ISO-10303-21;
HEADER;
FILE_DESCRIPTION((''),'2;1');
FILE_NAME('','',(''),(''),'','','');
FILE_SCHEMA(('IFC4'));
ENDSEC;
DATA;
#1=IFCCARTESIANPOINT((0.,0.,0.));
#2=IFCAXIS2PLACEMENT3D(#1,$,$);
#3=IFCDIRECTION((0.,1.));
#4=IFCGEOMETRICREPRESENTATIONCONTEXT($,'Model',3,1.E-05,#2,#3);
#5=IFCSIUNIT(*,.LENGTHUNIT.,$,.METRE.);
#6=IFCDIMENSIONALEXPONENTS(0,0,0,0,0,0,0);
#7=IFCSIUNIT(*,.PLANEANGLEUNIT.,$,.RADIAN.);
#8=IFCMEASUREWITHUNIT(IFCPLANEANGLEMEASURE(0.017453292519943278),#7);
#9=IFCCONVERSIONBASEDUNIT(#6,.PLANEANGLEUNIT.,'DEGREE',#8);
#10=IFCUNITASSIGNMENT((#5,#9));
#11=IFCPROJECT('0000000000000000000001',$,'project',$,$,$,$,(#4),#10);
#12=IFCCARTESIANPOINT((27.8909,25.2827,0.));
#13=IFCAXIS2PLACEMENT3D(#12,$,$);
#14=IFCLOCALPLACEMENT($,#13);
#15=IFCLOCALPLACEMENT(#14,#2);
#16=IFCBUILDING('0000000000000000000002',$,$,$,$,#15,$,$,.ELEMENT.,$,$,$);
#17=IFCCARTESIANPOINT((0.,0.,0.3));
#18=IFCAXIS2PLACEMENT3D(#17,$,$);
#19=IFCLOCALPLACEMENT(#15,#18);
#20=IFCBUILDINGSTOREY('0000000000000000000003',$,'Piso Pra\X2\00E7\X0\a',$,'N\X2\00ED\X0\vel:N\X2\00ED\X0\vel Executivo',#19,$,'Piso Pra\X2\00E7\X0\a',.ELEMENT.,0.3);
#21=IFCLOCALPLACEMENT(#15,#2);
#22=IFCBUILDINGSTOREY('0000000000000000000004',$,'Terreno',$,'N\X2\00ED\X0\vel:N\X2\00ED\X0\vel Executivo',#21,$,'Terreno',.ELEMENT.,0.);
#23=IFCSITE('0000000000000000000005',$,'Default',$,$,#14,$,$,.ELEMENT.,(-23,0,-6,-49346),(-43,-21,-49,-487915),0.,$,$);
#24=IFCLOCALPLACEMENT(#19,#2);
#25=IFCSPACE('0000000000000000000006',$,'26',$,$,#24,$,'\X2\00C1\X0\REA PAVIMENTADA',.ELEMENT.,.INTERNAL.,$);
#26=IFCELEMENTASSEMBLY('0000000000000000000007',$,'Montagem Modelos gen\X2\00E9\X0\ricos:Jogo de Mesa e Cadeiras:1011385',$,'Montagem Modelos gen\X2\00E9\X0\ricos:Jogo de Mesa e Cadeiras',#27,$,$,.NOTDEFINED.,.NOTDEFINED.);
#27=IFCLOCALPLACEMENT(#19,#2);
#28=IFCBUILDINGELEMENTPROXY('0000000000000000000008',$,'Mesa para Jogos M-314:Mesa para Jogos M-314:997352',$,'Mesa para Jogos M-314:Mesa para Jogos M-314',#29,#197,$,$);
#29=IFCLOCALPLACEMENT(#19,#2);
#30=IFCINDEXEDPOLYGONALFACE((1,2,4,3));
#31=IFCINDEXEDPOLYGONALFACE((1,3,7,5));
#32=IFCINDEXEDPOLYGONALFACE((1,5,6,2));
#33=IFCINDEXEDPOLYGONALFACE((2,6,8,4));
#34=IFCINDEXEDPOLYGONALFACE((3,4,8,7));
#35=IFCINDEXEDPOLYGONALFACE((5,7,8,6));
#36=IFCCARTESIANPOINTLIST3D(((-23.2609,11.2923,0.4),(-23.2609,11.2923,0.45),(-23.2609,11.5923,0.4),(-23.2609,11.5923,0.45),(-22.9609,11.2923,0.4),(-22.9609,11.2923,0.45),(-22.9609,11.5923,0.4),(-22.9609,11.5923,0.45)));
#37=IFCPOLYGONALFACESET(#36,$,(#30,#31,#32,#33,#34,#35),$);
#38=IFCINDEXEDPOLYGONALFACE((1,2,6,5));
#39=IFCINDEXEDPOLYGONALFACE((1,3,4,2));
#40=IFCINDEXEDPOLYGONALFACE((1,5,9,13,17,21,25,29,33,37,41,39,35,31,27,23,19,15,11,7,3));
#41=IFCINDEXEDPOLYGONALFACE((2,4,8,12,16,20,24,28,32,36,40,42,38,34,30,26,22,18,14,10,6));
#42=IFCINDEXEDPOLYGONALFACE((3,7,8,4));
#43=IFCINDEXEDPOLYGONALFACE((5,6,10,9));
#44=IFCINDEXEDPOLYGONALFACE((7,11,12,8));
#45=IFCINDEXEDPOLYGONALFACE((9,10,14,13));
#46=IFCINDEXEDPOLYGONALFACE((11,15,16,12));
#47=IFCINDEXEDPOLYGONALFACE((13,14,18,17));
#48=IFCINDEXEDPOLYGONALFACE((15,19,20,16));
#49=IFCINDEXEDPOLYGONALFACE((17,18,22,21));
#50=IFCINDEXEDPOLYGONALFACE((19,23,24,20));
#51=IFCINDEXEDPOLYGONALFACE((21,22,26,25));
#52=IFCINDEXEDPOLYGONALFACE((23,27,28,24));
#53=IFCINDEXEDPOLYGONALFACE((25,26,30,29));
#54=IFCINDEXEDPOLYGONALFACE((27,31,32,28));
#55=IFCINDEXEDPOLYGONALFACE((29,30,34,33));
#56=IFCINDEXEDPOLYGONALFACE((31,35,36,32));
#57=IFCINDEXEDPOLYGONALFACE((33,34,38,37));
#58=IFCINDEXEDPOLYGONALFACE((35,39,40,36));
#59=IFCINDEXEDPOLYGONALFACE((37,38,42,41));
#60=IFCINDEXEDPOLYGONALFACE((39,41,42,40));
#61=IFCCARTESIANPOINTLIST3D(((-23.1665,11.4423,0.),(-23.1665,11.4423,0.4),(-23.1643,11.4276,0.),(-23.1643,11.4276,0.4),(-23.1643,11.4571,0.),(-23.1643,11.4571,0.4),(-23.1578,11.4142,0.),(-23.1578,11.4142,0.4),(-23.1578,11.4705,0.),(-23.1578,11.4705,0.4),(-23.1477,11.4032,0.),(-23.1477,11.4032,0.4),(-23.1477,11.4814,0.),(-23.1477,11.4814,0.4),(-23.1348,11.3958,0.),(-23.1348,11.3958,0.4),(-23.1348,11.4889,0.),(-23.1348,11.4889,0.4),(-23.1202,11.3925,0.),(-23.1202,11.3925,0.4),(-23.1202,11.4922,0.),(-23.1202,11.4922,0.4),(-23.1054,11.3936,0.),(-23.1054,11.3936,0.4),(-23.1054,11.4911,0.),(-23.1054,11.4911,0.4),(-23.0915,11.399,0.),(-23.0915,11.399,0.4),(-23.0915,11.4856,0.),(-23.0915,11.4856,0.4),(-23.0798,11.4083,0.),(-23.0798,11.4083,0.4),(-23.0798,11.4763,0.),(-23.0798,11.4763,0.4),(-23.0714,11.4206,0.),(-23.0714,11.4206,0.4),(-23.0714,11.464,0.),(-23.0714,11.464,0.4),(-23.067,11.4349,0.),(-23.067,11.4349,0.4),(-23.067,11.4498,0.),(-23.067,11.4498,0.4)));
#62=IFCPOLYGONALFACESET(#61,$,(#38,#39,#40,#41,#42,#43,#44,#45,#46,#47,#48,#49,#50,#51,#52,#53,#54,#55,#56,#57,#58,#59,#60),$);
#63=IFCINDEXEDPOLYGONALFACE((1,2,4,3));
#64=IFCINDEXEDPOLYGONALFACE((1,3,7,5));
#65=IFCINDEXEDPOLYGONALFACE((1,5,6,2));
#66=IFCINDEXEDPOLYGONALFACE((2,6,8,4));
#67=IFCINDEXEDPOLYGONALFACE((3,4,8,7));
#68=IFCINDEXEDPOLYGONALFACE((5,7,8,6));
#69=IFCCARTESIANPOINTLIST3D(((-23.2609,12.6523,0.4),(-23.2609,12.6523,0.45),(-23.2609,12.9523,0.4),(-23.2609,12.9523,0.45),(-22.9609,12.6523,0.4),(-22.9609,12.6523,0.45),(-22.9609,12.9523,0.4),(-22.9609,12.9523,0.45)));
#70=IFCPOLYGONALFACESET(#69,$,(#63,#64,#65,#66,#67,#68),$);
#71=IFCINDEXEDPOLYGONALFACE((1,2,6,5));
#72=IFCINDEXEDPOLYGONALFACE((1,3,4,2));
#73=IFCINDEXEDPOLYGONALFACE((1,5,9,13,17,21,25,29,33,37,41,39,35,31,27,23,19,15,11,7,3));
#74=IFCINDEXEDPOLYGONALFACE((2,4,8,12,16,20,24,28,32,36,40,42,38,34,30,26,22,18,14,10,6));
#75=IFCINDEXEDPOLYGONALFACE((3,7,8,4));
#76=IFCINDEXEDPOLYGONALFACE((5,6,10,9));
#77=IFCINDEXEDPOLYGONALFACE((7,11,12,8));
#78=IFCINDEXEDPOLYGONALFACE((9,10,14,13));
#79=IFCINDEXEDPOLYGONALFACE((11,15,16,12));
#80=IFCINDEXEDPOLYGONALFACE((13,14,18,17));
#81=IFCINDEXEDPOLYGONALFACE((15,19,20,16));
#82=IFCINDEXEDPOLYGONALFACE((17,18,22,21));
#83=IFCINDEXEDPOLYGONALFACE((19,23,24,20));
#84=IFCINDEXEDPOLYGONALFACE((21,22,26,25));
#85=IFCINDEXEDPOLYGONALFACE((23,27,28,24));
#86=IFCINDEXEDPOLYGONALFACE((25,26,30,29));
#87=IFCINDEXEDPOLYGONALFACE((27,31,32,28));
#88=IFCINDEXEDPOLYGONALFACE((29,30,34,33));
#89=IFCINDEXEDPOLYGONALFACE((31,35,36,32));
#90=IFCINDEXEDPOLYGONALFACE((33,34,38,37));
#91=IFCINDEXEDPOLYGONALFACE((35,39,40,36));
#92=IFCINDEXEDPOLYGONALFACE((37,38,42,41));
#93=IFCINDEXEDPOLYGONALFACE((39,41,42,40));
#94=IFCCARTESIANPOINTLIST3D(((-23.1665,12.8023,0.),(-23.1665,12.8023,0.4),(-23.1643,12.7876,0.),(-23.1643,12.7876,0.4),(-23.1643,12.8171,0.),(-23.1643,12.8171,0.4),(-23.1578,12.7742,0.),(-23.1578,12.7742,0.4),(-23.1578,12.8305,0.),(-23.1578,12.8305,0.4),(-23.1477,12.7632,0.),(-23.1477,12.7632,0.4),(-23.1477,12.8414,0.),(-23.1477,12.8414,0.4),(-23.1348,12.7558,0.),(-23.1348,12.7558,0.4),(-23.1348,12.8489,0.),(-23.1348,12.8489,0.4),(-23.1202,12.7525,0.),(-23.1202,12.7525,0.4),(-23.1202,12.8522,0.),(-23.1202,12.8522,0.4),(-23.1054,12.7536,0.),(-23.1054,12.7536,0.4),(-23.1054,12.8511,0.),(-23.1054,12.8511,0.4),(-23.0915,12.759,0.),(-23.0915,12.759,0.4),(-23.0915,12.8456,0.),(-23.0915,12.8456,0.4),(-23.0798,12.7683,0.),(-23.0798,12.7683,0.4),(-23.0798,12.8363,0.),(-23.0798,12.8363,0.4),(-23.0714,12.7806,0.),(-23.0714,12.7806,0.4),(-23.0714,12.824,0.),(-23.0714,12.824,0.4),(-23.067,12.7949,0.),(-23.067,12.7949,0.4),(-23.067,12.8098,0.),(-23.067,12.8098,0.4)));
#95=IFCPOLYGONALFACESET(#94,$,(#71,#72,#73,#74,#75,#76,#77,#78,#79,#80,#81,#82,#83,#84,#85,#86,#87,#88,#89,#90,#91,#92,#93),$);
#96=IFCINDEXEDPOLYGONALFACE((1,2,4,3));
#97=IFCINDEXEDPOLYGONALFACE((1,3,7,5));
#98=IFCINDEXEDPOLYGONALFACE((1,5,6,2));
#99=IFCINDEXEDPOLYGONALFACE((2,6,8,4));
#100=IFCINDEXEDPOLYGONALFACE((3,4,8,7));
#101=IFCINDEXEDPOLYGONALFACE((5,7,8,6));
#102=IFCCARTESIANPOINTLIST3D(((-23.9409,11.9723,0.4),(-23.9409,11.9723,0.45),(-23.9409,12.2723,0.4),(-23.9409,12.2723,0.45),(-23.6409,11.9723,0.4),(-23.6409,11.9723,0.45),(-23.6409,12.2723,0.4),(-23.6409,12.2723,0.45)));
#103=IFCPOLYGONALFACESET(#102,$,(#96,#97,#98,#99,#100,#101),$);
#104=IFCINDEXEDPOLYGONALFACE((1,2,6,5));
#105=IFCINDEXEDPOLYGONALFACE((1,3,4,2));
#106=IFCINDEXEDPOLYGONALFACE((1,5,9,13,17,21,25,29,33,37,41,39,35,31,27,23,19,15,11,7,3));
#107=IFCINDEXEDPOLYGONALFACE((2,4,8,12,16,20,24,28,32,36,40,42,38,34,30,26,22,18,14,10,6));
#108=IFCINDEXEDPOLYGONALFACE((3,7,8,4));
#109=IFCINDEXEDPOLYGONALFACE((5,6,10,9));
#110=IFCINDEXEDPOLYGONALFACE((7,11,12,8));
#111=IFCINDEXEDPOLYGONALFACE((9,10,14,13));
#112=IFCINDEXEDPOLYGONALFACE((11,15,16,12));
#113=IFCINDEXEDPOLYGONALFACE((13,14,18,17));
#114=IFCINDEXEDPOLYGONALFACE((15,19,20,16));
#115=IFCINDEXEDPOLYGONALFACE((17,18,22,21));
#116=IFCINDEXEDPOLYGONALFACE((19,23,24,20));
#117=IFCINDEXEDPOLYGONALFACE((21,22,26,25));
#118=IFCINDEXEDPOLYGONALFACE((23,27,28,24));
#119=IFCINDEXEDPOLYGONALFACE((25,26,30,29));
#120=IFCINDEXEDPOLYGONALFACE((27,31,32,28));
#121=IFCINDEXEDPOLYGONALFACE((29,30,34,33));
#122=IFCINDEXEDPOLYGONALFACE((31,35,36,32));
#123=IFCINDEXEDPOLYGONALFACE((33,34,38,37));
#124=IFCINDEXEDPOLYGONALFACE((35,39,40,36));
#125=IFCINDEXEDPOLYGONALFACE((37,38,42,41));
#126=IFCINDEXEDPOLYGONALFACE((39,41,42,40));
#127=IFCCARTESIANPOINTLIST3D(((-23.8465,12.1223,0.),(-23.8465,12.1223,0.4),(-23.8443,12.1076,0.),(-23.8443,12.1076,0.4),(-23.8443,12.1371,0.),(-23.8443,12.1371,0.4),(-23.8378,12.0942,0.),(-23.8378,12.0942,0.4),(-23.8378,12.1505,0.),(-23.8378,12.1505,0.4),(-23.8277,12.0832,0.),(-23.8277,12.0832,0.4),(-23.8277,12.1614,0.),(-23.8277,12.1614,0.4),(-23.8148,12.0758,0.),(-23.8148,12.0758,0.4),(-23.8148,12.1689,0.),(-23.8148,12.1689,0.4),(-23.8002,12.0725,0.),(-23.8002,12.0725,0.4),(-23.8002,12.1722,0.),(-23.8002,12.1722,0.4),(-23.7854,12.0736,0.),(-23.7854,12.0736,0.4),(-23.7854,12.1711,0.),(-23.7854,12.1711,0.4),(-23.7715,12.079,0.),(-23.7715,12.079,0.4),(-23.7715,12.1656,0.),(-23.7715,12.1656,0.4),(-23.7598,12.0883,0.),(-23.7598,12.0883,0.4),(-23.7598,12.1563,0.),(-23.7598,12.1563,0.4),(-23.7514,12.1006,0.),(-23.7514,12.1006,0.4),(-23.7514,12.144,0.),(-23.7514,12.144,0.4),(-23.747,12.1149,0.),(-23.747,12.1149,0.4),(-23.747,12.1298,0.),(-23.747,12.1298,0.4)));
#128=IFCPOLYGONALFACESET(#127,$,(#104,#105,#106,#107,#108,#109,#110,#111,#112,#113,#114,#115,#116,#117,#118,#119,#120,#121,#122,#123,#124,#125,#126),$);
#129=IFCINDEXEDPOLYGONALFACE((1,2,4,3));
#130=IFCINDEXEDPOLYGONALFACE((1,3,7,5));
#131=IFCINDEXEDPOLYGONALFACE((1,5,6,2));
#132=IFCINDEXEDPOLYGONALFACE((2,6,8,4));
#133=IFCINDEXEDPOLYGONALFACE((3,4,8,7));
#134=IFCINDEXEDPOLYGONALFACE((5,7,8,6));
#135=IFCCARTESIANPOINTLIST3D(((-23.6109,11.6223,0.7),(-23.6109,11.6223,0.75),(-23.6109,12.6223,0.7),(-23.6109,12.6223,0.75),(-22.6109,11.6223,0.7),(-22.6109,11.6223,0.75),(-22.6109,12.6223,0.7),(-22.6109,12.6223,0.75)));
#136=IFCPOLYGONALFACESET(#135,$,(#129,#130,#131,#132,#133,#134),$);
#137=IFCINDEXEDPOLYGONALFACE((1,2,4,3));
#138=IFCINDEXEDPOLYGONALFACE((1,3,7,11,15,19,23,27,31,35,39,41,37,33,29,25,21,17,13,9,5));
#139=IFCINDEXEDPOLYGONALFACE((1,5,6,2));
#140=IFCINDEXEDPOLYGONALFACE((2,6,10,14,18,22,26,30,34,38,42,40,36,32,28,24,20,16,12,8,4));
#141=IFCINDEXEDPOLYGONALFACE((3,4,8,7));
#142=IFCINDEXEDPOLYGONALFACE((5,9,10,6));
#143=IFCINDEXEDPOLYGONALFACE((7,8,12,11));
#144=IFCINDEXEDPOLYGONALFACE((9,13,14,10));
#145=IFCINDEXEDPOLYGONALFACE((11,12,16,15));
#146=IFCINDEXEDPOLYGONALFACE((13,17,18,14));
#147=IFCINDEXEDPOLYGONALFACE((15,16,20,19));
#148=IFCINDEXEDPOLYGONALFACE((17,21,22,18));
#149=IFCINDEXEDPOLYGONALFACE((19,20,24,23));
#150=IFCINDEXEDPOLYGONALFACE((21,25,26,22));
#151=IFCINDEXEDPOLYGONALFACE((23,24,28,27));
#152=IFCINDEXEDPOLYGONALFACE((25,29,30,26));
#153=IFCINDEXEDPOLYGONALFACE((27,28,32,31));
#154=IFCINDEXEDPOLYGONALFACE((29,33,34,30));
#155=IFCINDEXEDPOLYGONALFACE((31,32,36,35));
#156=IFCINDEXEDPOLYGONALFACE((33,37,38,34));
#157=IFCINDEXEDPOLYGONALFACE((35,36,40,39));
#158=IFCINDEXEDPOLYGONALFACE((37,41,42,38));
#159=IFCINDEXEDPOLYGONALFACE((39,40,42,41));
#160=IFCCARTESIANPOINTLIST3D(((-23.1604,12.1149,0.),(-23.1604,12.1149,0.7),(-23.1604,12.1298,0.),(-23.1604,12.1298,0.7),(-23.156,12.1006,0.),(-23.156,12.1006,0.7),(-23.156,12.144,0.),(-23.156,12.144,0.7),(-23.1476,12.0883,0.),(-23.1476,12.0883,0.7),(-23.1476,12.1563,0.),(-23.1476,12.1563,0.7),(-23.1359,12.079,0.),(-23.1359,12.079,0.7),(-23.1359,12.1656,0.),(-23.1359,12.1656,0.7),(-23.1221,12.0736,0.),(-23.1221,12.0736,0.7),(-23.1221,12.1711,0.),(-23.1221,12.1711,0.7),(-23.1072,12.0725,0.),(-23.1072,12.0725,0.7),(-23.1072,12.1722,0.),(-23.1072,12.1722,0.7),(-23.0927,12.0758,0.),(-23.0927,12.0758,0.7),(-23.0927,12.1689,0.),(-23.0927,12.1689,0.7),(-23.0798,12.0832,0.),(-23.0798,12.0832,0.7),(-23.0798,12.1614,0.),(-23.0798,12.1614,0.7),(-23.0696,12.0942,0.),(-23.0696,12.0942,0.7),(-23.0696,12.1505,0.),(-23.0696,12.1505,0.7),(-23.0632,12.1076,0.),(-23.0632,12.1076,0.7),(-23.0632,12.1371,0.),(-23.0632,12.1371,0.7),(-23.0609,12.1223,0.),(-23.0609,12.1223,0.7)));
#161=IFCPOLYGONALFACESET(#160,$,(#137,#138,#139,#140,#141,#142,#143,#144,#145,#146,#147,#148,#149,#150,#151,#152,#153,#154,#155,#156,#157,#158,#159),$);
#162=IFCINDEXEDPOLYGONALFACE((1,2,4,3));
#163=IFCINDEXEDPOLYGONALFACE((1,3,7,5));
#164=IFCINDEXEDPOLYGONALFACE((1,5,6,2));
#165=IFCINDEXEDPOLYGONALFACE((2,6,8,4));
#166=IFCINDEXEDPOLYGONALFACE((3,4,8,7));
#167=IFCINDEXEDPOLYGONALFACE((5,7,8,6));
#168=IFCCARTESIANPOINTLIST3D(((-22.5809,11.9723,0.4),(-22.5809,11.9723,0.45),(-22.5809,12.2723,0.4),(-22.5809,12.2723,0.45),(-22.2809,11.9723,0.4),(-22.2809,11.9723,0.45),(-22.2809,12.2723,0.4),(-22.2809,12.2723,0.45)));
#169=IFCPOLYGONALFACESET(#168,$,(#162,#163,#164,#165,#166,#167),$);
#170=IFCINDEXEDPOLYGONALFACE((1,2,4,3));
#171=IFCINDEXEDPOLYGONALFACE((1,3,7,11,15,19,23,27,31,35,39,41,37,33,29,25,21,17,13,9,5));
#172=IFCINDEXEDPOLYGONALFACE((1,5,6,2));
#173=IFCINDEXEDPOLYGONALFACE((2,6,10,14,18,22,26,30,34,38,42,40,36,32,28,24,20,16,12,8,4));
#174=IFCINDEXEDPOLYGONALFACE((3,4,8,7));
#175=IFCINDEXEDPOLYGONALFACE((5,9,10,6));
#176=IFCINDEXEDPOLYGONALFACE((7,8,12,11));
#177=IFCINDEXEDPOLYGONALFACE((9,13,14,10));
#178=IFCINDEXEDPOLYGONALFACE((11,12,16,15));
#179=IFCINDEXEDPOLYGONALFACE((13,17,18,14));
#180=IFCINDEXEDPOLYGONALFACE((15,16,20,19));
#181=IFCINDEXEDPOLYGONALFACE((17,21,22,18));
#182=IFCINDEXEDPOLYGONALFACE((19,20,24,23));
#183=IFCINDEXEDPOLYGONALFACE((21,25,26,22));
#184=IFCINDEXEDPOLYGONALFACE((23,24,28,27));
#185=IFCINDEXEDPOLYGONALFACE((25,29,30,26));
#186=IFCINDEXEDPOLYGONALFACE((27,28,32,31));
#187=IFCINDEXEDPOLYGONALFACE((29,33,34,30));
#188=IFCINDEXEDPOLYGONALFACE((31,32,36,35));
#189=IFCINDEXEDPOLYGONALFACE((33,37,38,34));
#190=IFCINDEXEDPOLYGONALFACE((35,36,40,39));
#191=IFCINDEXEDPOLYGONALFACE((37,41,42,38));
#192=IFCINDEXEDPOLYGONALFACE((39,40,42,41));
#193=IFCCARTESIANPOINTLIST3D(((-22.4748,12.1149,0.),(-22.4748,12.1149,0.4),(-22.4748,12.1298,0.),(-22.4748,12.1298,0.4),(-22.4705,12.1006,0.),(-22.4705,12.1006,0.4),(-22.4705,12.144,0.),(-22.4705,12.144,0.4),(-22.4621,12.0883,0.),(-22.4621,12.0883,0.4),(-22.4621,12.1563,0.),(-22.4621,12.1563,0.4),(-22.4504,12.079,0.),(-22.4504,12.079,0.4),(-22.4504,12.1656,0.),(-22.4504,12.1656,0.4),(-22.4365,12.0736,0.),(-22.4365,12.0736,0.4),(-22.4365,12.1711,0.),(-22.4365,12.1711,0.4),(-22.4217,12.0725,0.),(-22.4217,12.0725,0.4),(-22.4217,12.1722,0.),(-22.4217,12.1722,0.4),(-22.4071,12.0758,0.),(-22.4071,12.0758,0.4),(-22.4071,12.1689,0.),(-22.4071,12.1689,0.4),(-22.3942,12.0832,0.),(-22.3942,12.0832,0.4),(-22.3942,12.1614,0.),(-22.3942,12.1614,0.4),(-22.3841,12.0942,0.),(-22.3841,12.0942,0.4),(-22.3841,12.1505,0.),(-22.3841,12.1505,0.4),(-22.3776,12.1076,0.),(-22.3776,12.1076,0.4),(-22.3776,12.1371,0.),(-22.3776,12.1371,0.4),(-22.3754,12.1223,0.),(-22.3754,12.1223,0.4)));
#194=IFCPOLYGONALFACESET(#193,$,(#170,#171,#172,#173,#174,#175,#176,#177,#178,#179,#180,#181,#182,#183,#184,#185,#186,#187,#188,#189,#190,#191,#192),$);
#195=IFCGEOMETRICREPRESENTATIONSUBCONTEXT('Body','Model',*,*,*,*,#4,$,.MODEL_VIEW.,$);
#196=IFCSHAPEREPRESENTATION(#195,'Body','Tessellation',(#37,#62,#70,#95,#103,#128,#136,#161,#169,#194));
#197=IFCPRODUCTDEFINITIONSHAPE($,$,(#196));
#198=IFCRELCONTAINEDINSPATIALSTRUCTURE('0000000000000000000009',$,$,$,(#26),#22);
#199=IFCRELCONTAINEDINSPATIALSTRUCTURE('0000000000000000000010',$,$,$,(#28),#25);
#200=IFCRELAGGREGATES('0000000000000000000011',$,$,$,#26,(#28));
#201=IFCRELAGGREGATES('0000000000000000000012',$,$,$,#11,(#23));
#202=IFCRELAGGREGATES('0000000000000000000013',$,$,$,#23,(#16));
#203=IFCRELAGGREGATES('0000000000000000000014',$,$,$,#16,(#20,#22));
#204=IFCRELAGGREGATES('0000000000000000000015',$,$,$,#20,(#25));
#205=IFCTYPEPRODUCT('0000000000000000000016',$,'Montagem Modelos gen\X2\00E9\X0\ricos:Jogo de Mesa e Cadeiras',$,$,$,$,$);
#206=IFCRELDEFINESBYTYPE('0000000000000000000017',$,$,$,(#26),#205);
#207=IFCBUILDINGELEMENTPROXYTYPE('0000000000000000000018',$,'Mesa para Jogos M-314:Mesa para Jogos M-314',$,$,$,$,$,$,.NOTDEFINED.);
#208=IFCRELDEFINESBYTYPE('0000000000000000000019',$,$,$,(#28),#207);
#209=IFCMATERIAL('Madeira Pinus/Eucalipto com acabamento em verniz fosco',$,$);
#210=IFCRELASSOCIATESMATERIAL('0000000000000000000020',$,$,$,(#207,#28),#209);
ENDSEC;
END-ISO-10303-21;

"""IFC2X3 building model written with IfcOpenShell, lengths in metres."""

from ifc_helpers import new_model, entity, si_unit, converted_unit, direction, frame, frame_2d, origin, place, context, subcontext, project, spatial, rectangle, circle, extrude, source, transform, mapped, material, type_object, type_shapes, element, aggregate, save


model = new_model("IFC2X3")

# Units and contexts
model_context = context("Model", 3, precision=1e-05, world=origin(), true_north=direction((0.0, 1.0)))
body_context = subcontext(model_context, "Body", "Model", "MODEL_VIEW")
ifc_project = project(units=[si_unit("LENGTHUNIT", "METRE"), converted_unit("PLANEANGLEUNIT", "DEGREE", entity("IfcPlaneAngleMeasure", 0.017453292519943278), si_unit("PLANEANGLEUNIT", "RADIAN"), dimensions=[0, 0, 0, 0, 0, 0, 0])], contexts=[model_context])

# Site, building, storey
site_placement = place(None, frame((27.8909, 25.2827, 0.0)))
site = spatial("IfcSite", under=ifc_project, at=site_placement, Name="Default", CompositionType="ELEMENT", RefLatitude=(-23, 0, -6, -49346), RefLongitude=(-43, -21, -49, -487915), RefElevation=0.0)
building_placement = place(site_placement, origin())
building = spatial("IfcBuilding", under=site, at=building_placement, CompositionType="ELEMENT")
storey_1_placement = place(building_placement, frame((0.0, 0.0, 0.3)))
storey_1 = spatial("IfcBuildingStorey", under=building, at=storey_1_placement, Name="Piso Praça", ObjectType="Nível:Nível Executivo", LongName="Piso Praça", CompositionType="ELEMENT", Elevation=0.3)

# Shared definitions
ifc_material_1 = material(Name="Madeira Pinus/Eucalipto com acabamento em verniz fosco")

# Shared definitions
space_1_placement = place(storey_1_placement, origin())
space_1 = spatial("IfcSpace", under=storey_1, at=space_1_placement, Name="26", LongName="ÁREA PAVIMENTADA", CompositionType="ELEMENT", InteriorOrExteriorSpace="INTERNAL")

# Shared definitions
building_element_proxy_type_1 = type_object("IfcBuildingElementProxyType", Name="Mesa para Jogos M-314:Mesa para Jogos M-314", PredefinedType="NOTDEFINED", material=ifc_material_1)
shared_shape_1 = source(origin(), body_context, "Body", "SweptSolid", [
    extrude(rectangle(XDim=0.3, YDim=0.3, at=frame_2d((0.0, 0.0), x_axis=(1.0, 0.0))), frame((0.0, -0.68, 0.4)), (0.0, 0.0, 1.0), 0.05),
    extrude(circle(Radius=0.05, at=frame_2d((0.0, 0.0), x_axis=(1.0, 0.0))), frame((-0.0055, -0.68, 0.0), z_axis=(0.0, 0.0, 1.0), x_axis=(-1.0, 0.0, 0.0)), (0.0, 0.0, 1.0), 0.4),
    extrude(rectangle(XDim=0.3, YDim=0.3, at=frame_2d((0.0, 0.0), x_axis=(1.0, 0.0))), frame((0.0, 0.68, 0.4), z_axis=(0.0, 0.0, 1.0), x_axis=(0.0, -1.0, 0.0)), (0.0, 0.0, 1.0), 0.05),
    extrude(circle(Radius=0.05, at=frame_2d((0.0, 0.0), x_axis=(1.0, 0.0))), frame((-0.0055, 0.68, 0.0), z_axis=(0.0, 0.0, 1.0), x_axis=(-1.0, 0.0, 0.0)), (0.0, 0.0, 1.0), 0.4),
    extrude(rectangle(XDim=0.3, YDim=0.3, at=frame_2d((0.0, 0.0), x_axis=(1.0, 0.0))), frame((-0.68, 0.0, 0.4), z_axis=(0.0, 0.0, 1.0), x_axis=(0.0, -1.0, 0.0)), (0.0, 0.0, 1.0), 0.05),
    extrude(circle(Radius=0.05, at=frame_2d((0.0, 0.0), x_axis=(1.0, 0.0))), frame((-0.6855, 0.0, 0.0), z_axis=(0.0, 0.0, 1.0), x_axis=(-1.0, 0.0, 0.0)), (0.0, 0.0, 1.0), 0.4),
    extrude(rectangle(XDim=1.0, YDim=1.0, at=frame_2d((0.0, 0.0), x_axis=(1.0, 0.0))), frame((0.0, 0.0, 0.7), z_axis=(0.0, 0.0, 1.0), x_axis=(-1.0, 0.0, 0.0)), (0.0, 0.0, 1.0), 0.05),
    extrude(circle(Radius=0.05, at=frame_2d((0.0, 0.0), x_axis=(1.0, 0.0))), origin(), (0.0, 0.0, 1.0), 0.7),
    extrude(rectangle(XDim=0.3, YDim=0.3, at=frame_2d((0.0, 0.0), x_axis=(1.0, 0.0))), frame((0.68, 0.0, 0.4), z_axis=(0.0, 0.0, 1.0), x_axis=(-1.0, 0.0, 0.0)), (0.0, 0.0, 1.0), 0.05),
    extrude(circle(Radius=0.05, at=frame_2d((0.0, 0.0), x_axis=(1.0, 0.0))), frame((0.6855, 0.0, 0.0)), (0.0, 0.0, 1.0), 0.4),
])
type_shapes(building_element_proxy_type_1, [shared_shape_1])

# Shared definitions
storey_2_placement = place(building_placement, origin())
storey_2 = spatial("IfcBuildingStorey", under=building, at=storey_2_placement, Name="Terreno", ObjectType="Nível:Nível Executivo", LongName="Terreno", CompositionType="ELEMENT", Elevation=0.0)

# Element assembly, building element proxy
type_product = type_object("IfcTypeProduct", Name="Montagem Modelos genéricos:Jogo de Mesa e Cadeiras")
assembly_placement = place(storey_2_placement, origin())
assembly = element("IfcElementAssembly", 1, at=assembly_placement, inside=storey_2, type_object=type_product, Name="Montagem Modelos genéricos:Jogo de Mesa e Cadeiras:1011385", ObjectType="Montagem Modelos genéricos:Jogo de Mesa e Cadeiras", AssemblyPlace="NOTDEFINED", PredefinedType="NOTDEFINED")
proxy_1_placement = place(assembly_placement, frame((-23.1109, 12.1223, 0.3)))
proxy_1 = element("IfcBuildingElementProxy", 2, at=proxy_1_placement, inside=space_1, type_object=building_element_proxy_type_1, material=ifc_material_1, Name="Mesa para Jogos M-314:Mesa para Jogos M-314:997352", ObjectType="Mesa para Jogos M-314:Mesa para Jogos M-314", context=body_context, shape_type="MappedRepresentation", body=[
    mapped(shared_shape_1, transform((0.0, 0.0, 0.0), scale=1.0)),
])
aggregate(assembly, [proxy_1])

save(model, "model.ifc")
